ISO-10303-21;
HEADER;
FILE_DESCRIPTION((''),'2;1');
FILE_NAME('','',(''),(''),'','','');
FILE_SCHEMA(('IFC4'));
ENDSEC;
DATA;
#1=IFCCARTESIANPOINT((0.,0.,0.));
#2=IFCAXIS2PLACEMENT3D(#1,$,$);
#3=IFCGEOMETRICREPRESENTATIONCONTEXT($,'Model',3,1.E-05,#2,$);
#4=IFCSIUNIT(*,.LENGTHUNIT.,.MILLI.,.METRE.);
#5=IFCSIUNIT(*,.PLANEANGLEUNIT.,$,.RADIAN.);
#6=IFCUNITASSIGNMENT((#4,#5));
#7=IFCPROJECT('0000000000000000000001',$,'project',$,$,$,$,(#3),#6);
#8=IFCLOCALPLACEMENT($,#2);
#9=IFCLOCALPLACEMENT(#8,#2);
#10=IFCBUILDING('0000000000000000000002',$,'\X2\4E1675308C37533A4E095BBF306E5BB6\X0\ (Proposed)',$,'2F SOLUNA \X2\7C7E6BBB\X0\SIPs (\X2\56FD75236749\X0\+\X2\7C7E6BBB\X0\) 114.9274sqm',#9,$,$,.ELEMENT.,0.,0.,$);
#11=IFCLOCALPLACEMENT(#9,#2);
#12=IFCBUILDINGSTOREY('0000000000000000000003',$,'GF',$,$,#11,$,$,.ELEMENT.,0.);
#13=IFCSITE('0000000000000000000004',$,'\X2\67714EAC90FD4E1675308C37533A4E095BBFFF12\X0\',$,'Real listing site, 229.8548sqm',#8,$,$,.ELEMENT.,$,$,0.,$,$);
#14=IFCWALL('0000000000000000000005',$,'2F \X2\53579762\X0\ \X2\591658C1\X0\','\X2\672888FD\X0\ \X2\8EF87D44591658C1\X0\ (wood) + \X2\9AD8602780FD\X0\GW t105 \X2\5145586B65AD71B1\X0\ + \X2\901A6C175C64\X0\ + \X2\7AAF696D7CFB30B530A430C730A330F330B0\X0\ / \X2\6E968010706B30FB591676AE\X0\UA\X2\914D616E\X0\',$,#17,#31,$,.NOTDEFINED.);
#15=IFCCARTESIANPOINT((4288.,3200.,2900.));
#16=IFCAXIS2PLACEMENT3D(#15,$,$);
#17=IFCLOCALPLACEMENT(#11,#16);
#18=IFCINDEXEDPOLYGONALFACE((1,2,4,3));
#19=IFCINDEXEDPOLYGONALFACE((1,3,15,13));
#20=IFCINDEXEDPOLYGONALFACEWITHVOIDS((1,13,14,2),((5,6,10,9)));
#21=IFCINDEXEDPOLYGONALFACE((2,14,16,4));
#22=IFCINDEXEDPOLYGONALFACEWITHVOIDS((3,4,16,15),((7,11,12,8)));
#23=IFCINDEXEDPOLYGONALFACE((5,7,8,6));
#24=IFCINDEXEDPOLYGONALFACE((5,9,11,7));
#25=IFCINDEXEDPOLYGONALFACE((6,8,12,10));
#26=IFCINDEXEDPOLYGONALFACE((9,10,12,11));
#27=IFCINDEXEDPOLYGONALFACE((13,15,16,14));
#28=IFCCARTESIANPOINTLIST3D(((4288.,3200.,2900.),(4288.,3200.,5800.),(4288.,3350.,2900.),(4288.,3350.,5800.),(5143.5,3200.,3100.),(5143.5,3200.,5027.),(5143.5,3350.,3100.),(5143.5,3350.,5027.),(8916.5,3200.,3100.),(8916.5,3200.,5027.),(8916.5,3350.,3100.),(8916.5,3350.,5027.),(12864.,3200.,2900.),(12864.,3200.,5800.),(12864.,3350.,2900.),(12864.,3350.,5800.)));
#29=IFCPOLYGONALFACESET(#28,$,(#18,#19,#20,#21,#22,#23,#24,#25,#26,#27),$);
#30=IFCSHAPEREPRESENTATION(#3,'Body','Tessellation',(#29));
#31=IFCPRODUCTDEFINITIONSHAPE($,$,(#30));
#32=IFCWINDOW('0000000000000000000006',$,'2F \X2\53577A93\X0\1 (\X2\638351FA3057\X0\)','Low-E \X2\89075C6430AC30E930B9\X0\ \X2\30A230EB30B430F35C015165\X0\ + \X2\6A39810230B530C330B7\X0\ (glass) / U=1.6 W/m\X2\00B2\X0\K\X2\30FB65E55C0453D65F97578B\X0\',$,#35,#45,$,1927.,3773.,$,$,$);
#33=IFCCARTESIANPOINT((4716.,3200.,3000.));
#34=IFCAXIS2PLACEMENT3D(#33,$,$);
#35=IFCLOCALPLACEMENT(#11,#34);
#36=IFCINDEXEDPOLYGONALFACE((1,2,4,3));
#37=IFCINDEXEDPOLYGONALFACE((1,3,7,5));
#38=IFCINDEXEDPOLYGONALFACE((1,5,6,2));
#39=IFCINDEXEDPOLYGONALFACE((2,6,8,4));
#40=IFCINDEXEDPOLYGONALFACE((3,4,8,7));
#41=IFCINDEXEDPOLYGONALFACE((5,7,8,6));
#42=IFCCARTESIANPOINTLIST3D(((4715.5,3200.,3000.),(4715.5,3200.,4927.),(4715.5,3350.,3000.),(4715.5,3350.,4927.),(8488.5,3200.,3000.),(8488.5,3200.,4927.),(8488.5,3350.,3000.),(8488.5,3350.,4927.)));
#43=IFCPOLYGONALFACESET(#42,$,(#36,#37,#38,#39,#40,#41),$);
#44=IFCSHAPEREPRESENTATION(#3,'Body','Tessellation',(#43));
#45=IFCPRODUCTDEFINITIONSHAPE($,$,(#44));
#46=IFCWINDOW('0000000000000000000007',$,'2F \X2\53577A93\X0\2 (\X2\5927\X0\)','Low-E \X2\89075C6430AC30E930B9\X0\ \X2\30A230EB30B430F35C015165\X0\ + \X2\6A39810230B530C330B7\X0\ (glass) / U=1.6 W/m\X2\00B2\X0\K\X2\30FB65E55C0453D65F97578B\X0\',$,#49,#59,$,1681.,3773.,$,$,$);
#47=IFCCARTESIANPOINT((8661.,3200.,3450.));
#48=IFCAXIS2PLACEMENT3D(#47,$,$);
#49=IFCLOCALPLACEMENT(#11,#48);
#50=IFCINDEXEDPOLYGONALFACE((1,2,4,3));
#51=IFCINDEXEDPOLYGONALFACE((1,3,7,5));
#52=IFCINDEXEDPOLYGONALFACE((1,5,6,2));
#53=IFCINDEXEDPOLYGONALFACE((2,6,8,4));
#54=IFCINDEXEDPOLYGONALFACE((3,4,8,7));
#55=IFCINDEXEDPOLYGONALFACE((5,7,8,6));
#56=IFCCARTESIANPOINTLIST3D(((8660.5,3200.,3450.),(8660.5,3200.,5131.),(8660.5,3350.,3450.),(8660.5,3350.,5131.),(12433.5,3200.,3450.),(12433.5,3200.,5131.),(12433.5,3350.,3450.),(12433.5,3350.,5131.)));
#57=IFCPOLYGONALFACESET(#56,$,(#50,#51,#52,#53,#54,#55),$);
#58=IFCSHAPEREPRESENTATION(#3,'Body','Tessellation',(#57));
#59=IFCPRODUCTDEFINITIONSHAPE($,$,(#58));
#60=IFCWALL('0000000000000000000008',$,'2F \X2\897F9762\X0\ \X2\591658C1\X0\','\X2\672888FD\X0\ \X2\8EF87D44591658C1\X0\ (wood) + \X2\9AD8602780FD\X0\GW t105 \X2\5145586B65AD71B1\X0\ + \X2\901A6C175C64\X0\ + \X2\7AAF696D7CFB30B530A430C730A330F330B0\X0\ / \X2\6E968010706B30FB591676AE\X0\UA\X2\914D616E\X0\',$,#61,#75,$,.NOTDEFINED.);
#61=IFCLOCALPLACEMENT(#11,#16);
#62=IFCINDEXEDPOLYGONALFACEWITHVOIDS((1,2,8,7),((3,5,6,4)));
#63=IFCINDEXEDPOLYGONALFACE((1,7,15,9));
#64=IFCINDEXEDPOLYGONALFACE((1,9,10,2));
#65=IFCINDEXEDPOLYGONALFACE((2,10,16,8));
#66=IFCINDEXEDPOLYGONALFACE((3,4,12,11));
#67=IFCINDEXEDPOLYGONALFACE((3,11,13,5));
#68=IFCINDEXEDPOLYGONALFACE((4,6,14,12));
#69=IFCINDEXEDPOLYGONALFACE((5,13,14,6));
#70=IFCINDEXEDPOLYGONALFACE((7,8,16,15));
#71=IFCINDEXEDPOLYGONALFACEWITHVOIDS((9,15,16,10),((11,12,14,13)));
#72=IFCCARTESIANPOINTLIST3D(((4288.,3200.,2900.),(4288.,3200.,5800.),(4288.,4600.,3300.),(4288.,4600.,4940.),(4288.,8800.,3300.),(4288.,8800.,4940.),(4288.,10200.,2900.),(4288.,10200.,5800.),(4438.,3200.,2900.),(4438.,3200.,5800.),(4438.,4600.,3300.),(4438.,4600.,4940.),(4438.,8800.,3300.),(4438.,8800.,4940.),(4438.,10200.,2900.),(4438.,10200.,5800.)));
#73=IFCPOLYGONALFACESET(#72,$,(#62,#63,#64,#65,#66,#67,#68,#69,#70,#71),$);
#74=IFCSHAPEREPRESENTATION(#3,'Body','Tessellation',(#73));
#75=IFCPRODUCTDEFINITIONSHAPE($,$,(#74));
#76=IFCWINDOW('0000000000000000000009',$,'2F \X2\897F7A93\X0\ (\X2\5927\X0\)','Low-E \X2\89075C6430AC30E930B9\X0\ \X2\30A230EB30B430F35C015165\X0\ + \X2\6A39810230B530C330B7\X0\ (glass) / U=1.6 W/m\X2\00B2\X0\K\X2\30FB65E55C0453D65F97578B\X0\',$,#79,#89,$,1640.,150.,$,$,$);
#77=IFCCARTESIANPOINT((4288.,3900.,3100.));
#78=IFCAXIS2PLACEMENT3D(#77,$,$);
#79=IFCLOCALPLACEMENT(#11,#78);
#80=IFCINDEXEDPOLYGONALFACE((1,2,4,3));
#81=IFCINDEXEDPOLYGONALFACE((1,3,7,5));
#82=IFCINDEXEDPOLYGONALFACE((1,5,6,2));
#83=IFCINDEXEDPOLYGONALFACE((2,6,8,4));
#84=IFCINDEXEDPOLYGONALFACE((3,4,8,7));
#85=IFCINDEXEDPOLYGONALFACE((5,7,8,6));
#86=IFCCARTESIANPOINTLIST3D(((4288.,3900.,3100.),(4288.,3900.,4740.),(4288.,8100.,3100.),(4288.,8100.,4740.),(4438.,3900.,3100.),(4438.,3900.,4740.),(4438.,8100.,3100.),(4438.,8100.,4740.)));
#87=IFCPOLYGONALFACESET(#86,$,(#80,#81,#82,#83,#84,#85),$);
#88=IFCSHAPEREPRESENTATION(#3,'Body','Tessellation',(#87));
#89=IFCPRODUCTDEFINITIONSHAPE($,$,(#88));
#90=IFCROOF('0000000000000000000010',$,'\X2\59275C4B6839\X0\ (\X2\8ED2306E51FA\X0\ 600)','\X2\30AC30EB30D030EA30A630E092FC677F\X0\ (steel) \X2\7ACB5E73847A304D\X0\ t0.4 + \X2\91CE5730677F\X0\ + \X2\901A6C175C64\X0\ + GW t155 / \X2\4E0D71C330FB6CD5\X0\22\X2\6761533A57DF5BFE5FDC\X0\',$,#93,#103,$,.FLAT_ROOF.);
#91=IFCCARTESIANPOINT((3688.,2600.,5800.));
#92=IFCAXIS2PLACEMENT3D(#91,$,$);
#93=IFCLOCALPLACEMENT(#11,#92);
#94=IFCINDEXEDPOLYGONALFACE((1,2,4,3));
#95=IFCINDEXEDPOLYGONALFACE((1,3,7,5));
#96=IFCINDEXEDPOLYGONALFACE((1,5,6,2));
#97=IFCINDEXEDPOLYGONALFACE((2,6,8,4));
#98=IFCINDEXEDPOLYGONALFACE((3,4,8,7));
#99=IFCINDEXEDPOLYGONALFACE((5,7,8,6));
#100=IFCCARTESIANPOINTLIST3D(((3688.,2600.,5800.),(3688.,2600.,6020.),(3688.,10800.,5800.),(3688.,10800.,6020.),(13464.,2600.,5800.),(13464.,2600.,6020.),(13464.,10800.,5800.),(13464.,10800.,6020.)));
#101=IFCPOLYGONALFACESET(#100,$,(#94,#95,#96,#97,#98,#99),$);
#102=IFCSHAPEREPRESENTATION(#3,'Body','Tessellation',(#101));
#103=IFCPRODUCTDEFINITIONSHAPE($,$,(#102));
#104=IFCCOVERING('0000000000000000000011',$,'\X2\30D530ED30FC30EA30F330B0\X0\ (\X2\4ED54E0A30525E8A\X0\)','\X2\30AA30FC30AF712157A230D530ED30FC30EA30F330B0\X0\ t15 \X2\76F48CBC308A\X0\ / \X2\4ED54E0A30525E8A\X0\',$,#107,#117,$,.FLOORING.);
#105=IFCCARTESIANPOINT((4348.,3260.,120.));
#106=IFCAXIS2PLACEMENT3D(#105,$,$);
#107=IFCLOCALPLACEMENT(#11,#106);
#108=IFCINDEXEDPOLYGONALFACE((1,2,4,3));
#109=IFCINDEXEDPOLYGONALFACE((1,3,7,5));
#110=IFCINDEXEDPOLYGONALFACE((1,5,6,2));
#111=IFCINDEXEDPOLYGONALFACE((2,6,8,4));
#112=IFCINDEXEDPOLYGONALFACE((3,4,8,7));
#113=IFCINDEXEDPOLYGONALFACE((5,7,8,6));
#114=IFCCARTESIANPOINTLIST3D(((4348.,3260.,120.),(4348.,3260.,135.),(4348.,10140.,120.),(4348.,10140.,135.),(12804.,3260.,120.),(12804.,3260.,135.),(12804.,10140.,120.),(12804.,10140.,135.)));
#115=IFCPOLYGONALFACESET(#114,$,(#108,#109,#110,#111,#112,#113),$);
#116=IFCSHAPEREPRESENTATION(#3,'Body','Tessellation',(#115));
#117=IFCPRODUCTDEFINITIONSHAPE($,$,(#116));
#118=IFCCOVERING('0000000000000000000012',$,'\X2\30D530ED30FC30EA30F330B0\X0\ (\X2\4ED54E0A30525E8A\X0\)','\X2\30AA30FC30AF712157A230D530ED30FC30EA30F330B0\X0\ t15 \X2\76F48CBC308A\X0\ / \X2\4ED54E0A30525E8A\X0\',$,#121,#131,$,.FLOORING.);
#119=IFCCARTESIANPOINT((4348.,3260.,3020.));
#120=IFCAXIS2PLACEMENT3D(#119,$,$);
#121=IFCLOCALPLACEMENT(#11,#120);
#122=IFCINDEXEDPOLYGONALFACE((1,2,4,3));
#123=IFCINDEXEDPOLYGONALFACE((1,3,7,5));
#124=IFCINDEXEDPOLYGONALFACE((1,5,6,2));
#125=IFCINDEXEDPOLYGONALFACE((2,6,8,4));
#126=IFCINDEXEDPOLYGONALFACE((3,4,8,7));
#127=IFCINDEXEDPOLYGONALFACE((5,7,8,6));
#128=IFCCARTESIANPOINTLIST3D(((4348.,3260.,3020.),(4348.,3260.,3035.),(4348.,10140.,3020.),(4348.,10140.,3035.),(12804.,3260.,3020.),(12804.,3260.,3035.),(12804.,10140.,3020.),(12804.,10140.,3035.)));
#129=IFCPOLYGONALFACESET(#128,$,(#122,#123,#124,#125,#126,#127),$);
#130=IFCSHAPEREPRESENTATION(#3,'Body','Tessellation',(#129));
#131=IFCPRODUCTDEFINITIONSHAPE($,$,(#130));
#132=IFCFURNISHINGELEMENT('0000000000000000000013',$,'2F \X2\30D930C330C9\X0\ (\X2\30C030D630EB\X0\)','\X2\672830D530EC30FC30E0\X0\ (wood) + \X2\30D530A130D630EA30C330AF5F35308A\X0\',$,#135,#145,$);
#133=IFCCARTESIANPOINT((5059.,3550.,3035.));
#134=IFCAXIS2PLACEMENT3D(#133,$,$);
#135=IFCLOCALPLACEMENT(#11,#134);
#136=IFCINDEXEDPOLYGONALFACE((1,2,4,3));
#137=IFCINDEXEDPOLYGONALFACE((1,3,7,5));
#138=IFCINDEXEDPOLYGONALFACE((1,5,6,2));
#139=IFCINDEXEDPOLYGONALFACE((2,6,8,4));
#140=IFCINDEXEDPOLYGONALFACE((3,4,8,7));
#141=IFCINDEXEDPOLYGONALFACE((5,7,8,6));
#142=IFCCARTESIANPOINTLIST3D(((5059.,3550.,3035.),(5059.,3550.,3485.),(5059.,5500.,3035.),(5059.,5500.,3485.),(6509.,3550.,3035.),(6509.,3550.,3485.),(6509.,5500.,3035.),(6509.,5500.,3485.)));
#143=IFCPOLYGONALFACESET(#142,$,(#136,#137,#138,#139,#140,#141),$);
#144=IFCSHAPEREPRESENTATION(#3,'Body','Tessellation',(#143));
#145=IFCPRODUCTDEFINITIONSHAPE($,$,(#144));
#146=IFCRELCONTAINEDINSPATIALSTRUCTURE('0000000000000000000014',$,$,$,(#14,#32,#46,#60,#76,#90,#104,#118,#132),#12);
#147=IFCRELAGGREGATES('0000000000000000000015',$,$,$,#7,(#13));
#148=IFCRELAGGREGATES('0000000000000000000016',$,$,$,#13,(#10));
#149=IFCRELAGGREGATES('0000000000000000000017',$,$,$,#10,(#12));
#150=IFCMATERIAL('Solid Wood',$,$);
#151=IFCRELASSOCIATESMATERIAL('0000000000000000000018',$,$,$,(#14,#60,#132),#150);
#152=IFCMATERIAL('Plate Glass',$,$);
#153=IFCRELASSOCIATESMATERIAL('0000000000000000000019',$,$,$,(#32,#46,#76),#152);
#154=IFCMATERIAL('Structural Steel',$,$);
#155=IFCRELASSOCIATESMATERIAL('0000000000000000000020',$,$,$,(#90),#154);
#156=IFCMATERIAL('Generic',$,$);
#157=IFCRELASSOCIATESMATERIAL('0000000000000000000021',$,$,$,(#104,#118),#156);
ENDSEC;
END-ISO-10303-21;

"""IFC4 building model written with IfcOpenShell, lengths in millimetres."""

from ifc_helpers import new_model, si_unit, frame, frame_2d, origin, place, context, project, spatial, rectangle, extrude, material, element, fill, save


model = new_model("IFC4")

# Units and contexts
model_context = context("Model", 3, precision=1e-05, world=origin())
ifc_project = project(units=[si_unit("LENGTHUNIT", "METRE", prefix="MILLI"), si_unit("PLANEANGLEUNIT", "RADIAN")], contexts=[model_context])

# Site, building, storey
site_placement = place(None, origin())
site = spatial("IfcSite", under=ifc_project, at=site_placement, Name="東京都世田谷区三宿２", ObjectType="Real listing site, 229.8548sqm", CompositionType="ELEMENT", RefElevation=0.0)
building_placement = place(site_placement, origin())
building = spatial("IfcBuilding", under=site, at=building_placement, Name="世田谷区三宿の家 (Proposed)", ObjectType="2F SOLUNA 籾殻SIPs (国産杉+籾殻) 114.9274sqm", CompositionType="ELEMENT", ElevationOfRefHeight=0.0, ElevationOfTerrain=0.0)
storey_placement = place(building_placement, origin())
storey = spatial("IfcBuildingStorey", under=building, at=storey_placement, Name="GF", CompositionType="ELEMENT", Elevation=0.0)

# Shared definitions
ifc_material_1 = material(Name="Solid Wood")

# Shared definitions
ifc_material_2 = material(Name="Plate Glass")

# Wall, openings, windows
wall_1_placement = place(storey_placement, frame((4288.0, 3200.0, 2900.0)))
wall_1 = element("IfcWall", 1, at=wall_1_placement, inside=storey, material=ifc_material_1, Name="2F 南面 外壁", Description="木製 軸組外壁 (wood) + 高性能GW t105 充填断熱 + 通気層 + 窯業系サイディング / 準耐火・外皮UA配慮", PredefinedType="NOTDEFINED", context=model_context, shape_type="SweptSolid", body=[
    extrude(rectangle(XDim=8576.0, YDim=150.0, at=frame_2d((4288.0, 75.0))), frame((4288.0, 3200.0, 2900.0)), (0.0, 0.0, 1.0), 2900.0),
])
opening_1_placement = place(storey_placement, frame((4716.0, 3200.0, 3000.0)))
opening_1 = element("IfcOpeningElement", 2, at=opening_1_placement, cuts=wall_1, PredefinedType="NOTDEFINED", context=model_context, shape_type="SweptSolid", body=[
    extrude(rectangle(XDim=3773.0, YDim=150.0, at=frame_2d((1886.0, 75.0))), frame((4716.0, 3200.0, 3000.0)), (0.0, 0.0, 1.0), 1927.0),
])
opening_2_placement = place(storey_placement, frame((8661.0, 3200.0, 3450.0)))
opening_2 = element("IfcOpeningElement", 3, at=opening_2_placement, cuts=wall_1, PredefinedType="NOTDEFINED", context=model_context, shape_type="SweptSolid", body=[
    extrude(rectangle(XDim=3773.0, YDim=150.0, at=frame_2d((1886.0, 75.0))), frame((8661.0, 3200.0, 3450.0)), (0.0, 0.0, 1.0), 1681.0),
])
window_1_placement = place(storey_placement, frame((4716.0, 3200.0, 3000.0)))
window_1 = element("IfcWindow", 4, at=window_1_placement, inside=storey, material=ifc_material_2, Name="2F 南窓1 (掃出し)", Description="Low-E 複層ガラス アルゴン封入 + 樹脂サッシ (glass) / U=1.6 W/m²K・日射取得型", OverallHeight=1927.0, OverallWidth=3773.0, context=model_context, shape_type="SweptSolid", body=[
    extrude(rectangle(XDim=3773.0, YDim=150.0, at=frame_2d((1886.0, 75.0))), frame((4716.0, 3200.0, 3000.0)), (0.0, 0.0, 1.0), 1927.0),
])
fill(opening_1, window_1)
window_2_placement = place(storey_placement, frame((8661.0, 3200.0, 3450.0)))
window_2 = element("IfcWindow", 5, at=window_2_placement, inside=storey, material=ifc_material_2, Name="2F 南窓2 (大)", Description="Low-E 複層ガラス アルゴン封入 + 樹脂サッシ (glass) / U=1.6 W/m²K・日射取得型", OverallHeight=1681.0, OverallWidth=3773.0, context=model_context, shape_type="SweptSolid", body=[
    extrude(rectangle(XDim=3773.0, YDim=150.0, at=frame_2d((1886.0, 75.0))), frame((8661.0, 3200.0, 3450.0)), (0.0, 0.0, 1.0), 1681.0),
])
fill(opening_2, window_2)

# Wall, opening, window
wall_2_placement = place(storey_placement, frame((4288.0, 3200.0, 2900.0)))
wall_2 = element("IfcWall", 6, at=wall_2_placement, inside=storey, material=ifc_material_1, Name="2F 西面 外壁", Description="木製 軸組外壁 (wood) + 高性能GW t105 充填断熱 + 通気層 + 窯業系サイディング / 準耐火・外皮UA配慮", PredefinedType="NOTDEFINED", context=model_context, shape_type="SweptSolid", body=[
    extrude(rectangle(XDim=150.0, YDim=7000.0, at=frame_2d((75.0, 3500.0))), frame((4288.0, 3200.0, 2900.0)), (0.0, 0.0, 1.0), 2900.0),
])
opening_3_placement = place(storey_placement, frame((4288.0, 3900.0, 3100.0)))
opening_3 = element("IfcOpeningElement", 7, at=opening_3_placement, cuts=wall_2, PredefinedType="NOTDEFINED", context=model_context, shape_type="SweptSolid", body=[
    extrude(rectangle(XDim=150.0, YDim=4200.0, at=frame_2d((75.0, 2100.0))), frame((4288.0, 3900.0, 3100.0)), (0.0, 0.0, 1.0), 1640.0),
])
window_3_placement = place(storey_placement, frame((4288.0, 3900.0, 3100.0)))
window_3 = element("IfcWindow", 8, at=window_3_placement, inside=storey, material=ifc_material_2, Name="2F 西窓 (大)", Description="Low-E 複層ガラス アルゴン封入 + 樹脂サッシ (glass) / U=1.6 W/m²K・日射取得型", OverallHeight=1640.0, OverallWidth=150.0, context=model_context, shape_type="SweptSolid", body=[
    extrude(rectangle(XDim=150.0, YDim=4200.0, at=frame_2d((75.0, 2100.0))), frame((4288.0, 3900.0, 3100.0)), (0.0, 0.0, 1.0), 1640.0),
])
fill(opening_3, window_3)

# Roof
ifc_material_3 = material(Name="Structural Steel")
roof_placement = place(storey_placement, frame((3688.0, 2600.0, 5800.0)))
element("IfcRoof", 9, at=roof_placement, inside=storey, material=ifc_material_3, Name="大屋根 (軒の出 600)", Description="ガルバリウム鋼板 (steel) 立平葺き t0.4 + 野地板 + 通気層 + GW t155 / 不燃・法22条区域対応", PredefinedType="FLAT_ROOF", context=model_context, shape_type="SweptSolid", body=[
    extrude(rectangle(XDim=9776.0, YDim=8200.0, at=frame_2d((4888.0, 4100.0))), frame((3688.0, 2600.0, 5800.0)), (0.0, 0.0, 1.0), 220.0),
])

# Coverings
ifc_material_4 = material(Name="Generic")
covering_1_placement = place(storey_placement, frame((4348.0, 3260.0, 120.0)))
element("IfcCovering", 10, at=covering_1_placement, inside=storey, material=ifc_material_4, Name="フローリング (仕上げ床)", Description="オーク無垢フローリング t15 直貼り / 仕上げ床", PredefinedType="FLOORING", context=model_context, shape_type="SweptSolid", body=[
    extrude(rectangle(XDim=8456.0, YDim=6880.0, at=frame_2d((4228.0, 3440.0))), frame((4348.0, 3260.0, 120.0)), (0.0, 0.0, 1.0), 15.0),
])
covering_2_placement = place(storey_placement, frame((4348.0, 3260.0, 3020.0)))
element("IfcCovering", 11, at=covering_2_placement, inside=storey, material=ifc_material_4, Name="フローリング (仕上げ床)", Description="オーク無垢フローリング t15 直貼り / 仕上げ床", PredefinedType="FLOORING", context=model_context, shape_type="SweptSolid", body=[
    extrude(rectangle(XDim=8456.0, YDim=6880.0, at=frame_2d((4228.0, 3440.0))), frame((4348.0, 3260.0, 3020.0)), (0.0, 0.0, 1.0), 15.0),
])

# Furnishing element
furnishing_placement = place(storey_placement, frame((5059.0, 3550.0, 3035.0)))
element("IfcFurnishingElement", 12, at=furnishing_placement, inside=storey, material=ifc_material_1, Name="2F ベッド (ダブル)", Description="木フレーム (wood) + ファブリック張り", context=model_context, shape_type="SweptSolid", body=[
    extrude(rectangle(XDim=1450.0, YDim=1950.0, at=frame_2d((725.0, 975.0))), frame((5059.0, 3550.0, 3035.0)), (0.0, 0.0, 1.0), 450.0),
])

save(model, "model.ifc")
